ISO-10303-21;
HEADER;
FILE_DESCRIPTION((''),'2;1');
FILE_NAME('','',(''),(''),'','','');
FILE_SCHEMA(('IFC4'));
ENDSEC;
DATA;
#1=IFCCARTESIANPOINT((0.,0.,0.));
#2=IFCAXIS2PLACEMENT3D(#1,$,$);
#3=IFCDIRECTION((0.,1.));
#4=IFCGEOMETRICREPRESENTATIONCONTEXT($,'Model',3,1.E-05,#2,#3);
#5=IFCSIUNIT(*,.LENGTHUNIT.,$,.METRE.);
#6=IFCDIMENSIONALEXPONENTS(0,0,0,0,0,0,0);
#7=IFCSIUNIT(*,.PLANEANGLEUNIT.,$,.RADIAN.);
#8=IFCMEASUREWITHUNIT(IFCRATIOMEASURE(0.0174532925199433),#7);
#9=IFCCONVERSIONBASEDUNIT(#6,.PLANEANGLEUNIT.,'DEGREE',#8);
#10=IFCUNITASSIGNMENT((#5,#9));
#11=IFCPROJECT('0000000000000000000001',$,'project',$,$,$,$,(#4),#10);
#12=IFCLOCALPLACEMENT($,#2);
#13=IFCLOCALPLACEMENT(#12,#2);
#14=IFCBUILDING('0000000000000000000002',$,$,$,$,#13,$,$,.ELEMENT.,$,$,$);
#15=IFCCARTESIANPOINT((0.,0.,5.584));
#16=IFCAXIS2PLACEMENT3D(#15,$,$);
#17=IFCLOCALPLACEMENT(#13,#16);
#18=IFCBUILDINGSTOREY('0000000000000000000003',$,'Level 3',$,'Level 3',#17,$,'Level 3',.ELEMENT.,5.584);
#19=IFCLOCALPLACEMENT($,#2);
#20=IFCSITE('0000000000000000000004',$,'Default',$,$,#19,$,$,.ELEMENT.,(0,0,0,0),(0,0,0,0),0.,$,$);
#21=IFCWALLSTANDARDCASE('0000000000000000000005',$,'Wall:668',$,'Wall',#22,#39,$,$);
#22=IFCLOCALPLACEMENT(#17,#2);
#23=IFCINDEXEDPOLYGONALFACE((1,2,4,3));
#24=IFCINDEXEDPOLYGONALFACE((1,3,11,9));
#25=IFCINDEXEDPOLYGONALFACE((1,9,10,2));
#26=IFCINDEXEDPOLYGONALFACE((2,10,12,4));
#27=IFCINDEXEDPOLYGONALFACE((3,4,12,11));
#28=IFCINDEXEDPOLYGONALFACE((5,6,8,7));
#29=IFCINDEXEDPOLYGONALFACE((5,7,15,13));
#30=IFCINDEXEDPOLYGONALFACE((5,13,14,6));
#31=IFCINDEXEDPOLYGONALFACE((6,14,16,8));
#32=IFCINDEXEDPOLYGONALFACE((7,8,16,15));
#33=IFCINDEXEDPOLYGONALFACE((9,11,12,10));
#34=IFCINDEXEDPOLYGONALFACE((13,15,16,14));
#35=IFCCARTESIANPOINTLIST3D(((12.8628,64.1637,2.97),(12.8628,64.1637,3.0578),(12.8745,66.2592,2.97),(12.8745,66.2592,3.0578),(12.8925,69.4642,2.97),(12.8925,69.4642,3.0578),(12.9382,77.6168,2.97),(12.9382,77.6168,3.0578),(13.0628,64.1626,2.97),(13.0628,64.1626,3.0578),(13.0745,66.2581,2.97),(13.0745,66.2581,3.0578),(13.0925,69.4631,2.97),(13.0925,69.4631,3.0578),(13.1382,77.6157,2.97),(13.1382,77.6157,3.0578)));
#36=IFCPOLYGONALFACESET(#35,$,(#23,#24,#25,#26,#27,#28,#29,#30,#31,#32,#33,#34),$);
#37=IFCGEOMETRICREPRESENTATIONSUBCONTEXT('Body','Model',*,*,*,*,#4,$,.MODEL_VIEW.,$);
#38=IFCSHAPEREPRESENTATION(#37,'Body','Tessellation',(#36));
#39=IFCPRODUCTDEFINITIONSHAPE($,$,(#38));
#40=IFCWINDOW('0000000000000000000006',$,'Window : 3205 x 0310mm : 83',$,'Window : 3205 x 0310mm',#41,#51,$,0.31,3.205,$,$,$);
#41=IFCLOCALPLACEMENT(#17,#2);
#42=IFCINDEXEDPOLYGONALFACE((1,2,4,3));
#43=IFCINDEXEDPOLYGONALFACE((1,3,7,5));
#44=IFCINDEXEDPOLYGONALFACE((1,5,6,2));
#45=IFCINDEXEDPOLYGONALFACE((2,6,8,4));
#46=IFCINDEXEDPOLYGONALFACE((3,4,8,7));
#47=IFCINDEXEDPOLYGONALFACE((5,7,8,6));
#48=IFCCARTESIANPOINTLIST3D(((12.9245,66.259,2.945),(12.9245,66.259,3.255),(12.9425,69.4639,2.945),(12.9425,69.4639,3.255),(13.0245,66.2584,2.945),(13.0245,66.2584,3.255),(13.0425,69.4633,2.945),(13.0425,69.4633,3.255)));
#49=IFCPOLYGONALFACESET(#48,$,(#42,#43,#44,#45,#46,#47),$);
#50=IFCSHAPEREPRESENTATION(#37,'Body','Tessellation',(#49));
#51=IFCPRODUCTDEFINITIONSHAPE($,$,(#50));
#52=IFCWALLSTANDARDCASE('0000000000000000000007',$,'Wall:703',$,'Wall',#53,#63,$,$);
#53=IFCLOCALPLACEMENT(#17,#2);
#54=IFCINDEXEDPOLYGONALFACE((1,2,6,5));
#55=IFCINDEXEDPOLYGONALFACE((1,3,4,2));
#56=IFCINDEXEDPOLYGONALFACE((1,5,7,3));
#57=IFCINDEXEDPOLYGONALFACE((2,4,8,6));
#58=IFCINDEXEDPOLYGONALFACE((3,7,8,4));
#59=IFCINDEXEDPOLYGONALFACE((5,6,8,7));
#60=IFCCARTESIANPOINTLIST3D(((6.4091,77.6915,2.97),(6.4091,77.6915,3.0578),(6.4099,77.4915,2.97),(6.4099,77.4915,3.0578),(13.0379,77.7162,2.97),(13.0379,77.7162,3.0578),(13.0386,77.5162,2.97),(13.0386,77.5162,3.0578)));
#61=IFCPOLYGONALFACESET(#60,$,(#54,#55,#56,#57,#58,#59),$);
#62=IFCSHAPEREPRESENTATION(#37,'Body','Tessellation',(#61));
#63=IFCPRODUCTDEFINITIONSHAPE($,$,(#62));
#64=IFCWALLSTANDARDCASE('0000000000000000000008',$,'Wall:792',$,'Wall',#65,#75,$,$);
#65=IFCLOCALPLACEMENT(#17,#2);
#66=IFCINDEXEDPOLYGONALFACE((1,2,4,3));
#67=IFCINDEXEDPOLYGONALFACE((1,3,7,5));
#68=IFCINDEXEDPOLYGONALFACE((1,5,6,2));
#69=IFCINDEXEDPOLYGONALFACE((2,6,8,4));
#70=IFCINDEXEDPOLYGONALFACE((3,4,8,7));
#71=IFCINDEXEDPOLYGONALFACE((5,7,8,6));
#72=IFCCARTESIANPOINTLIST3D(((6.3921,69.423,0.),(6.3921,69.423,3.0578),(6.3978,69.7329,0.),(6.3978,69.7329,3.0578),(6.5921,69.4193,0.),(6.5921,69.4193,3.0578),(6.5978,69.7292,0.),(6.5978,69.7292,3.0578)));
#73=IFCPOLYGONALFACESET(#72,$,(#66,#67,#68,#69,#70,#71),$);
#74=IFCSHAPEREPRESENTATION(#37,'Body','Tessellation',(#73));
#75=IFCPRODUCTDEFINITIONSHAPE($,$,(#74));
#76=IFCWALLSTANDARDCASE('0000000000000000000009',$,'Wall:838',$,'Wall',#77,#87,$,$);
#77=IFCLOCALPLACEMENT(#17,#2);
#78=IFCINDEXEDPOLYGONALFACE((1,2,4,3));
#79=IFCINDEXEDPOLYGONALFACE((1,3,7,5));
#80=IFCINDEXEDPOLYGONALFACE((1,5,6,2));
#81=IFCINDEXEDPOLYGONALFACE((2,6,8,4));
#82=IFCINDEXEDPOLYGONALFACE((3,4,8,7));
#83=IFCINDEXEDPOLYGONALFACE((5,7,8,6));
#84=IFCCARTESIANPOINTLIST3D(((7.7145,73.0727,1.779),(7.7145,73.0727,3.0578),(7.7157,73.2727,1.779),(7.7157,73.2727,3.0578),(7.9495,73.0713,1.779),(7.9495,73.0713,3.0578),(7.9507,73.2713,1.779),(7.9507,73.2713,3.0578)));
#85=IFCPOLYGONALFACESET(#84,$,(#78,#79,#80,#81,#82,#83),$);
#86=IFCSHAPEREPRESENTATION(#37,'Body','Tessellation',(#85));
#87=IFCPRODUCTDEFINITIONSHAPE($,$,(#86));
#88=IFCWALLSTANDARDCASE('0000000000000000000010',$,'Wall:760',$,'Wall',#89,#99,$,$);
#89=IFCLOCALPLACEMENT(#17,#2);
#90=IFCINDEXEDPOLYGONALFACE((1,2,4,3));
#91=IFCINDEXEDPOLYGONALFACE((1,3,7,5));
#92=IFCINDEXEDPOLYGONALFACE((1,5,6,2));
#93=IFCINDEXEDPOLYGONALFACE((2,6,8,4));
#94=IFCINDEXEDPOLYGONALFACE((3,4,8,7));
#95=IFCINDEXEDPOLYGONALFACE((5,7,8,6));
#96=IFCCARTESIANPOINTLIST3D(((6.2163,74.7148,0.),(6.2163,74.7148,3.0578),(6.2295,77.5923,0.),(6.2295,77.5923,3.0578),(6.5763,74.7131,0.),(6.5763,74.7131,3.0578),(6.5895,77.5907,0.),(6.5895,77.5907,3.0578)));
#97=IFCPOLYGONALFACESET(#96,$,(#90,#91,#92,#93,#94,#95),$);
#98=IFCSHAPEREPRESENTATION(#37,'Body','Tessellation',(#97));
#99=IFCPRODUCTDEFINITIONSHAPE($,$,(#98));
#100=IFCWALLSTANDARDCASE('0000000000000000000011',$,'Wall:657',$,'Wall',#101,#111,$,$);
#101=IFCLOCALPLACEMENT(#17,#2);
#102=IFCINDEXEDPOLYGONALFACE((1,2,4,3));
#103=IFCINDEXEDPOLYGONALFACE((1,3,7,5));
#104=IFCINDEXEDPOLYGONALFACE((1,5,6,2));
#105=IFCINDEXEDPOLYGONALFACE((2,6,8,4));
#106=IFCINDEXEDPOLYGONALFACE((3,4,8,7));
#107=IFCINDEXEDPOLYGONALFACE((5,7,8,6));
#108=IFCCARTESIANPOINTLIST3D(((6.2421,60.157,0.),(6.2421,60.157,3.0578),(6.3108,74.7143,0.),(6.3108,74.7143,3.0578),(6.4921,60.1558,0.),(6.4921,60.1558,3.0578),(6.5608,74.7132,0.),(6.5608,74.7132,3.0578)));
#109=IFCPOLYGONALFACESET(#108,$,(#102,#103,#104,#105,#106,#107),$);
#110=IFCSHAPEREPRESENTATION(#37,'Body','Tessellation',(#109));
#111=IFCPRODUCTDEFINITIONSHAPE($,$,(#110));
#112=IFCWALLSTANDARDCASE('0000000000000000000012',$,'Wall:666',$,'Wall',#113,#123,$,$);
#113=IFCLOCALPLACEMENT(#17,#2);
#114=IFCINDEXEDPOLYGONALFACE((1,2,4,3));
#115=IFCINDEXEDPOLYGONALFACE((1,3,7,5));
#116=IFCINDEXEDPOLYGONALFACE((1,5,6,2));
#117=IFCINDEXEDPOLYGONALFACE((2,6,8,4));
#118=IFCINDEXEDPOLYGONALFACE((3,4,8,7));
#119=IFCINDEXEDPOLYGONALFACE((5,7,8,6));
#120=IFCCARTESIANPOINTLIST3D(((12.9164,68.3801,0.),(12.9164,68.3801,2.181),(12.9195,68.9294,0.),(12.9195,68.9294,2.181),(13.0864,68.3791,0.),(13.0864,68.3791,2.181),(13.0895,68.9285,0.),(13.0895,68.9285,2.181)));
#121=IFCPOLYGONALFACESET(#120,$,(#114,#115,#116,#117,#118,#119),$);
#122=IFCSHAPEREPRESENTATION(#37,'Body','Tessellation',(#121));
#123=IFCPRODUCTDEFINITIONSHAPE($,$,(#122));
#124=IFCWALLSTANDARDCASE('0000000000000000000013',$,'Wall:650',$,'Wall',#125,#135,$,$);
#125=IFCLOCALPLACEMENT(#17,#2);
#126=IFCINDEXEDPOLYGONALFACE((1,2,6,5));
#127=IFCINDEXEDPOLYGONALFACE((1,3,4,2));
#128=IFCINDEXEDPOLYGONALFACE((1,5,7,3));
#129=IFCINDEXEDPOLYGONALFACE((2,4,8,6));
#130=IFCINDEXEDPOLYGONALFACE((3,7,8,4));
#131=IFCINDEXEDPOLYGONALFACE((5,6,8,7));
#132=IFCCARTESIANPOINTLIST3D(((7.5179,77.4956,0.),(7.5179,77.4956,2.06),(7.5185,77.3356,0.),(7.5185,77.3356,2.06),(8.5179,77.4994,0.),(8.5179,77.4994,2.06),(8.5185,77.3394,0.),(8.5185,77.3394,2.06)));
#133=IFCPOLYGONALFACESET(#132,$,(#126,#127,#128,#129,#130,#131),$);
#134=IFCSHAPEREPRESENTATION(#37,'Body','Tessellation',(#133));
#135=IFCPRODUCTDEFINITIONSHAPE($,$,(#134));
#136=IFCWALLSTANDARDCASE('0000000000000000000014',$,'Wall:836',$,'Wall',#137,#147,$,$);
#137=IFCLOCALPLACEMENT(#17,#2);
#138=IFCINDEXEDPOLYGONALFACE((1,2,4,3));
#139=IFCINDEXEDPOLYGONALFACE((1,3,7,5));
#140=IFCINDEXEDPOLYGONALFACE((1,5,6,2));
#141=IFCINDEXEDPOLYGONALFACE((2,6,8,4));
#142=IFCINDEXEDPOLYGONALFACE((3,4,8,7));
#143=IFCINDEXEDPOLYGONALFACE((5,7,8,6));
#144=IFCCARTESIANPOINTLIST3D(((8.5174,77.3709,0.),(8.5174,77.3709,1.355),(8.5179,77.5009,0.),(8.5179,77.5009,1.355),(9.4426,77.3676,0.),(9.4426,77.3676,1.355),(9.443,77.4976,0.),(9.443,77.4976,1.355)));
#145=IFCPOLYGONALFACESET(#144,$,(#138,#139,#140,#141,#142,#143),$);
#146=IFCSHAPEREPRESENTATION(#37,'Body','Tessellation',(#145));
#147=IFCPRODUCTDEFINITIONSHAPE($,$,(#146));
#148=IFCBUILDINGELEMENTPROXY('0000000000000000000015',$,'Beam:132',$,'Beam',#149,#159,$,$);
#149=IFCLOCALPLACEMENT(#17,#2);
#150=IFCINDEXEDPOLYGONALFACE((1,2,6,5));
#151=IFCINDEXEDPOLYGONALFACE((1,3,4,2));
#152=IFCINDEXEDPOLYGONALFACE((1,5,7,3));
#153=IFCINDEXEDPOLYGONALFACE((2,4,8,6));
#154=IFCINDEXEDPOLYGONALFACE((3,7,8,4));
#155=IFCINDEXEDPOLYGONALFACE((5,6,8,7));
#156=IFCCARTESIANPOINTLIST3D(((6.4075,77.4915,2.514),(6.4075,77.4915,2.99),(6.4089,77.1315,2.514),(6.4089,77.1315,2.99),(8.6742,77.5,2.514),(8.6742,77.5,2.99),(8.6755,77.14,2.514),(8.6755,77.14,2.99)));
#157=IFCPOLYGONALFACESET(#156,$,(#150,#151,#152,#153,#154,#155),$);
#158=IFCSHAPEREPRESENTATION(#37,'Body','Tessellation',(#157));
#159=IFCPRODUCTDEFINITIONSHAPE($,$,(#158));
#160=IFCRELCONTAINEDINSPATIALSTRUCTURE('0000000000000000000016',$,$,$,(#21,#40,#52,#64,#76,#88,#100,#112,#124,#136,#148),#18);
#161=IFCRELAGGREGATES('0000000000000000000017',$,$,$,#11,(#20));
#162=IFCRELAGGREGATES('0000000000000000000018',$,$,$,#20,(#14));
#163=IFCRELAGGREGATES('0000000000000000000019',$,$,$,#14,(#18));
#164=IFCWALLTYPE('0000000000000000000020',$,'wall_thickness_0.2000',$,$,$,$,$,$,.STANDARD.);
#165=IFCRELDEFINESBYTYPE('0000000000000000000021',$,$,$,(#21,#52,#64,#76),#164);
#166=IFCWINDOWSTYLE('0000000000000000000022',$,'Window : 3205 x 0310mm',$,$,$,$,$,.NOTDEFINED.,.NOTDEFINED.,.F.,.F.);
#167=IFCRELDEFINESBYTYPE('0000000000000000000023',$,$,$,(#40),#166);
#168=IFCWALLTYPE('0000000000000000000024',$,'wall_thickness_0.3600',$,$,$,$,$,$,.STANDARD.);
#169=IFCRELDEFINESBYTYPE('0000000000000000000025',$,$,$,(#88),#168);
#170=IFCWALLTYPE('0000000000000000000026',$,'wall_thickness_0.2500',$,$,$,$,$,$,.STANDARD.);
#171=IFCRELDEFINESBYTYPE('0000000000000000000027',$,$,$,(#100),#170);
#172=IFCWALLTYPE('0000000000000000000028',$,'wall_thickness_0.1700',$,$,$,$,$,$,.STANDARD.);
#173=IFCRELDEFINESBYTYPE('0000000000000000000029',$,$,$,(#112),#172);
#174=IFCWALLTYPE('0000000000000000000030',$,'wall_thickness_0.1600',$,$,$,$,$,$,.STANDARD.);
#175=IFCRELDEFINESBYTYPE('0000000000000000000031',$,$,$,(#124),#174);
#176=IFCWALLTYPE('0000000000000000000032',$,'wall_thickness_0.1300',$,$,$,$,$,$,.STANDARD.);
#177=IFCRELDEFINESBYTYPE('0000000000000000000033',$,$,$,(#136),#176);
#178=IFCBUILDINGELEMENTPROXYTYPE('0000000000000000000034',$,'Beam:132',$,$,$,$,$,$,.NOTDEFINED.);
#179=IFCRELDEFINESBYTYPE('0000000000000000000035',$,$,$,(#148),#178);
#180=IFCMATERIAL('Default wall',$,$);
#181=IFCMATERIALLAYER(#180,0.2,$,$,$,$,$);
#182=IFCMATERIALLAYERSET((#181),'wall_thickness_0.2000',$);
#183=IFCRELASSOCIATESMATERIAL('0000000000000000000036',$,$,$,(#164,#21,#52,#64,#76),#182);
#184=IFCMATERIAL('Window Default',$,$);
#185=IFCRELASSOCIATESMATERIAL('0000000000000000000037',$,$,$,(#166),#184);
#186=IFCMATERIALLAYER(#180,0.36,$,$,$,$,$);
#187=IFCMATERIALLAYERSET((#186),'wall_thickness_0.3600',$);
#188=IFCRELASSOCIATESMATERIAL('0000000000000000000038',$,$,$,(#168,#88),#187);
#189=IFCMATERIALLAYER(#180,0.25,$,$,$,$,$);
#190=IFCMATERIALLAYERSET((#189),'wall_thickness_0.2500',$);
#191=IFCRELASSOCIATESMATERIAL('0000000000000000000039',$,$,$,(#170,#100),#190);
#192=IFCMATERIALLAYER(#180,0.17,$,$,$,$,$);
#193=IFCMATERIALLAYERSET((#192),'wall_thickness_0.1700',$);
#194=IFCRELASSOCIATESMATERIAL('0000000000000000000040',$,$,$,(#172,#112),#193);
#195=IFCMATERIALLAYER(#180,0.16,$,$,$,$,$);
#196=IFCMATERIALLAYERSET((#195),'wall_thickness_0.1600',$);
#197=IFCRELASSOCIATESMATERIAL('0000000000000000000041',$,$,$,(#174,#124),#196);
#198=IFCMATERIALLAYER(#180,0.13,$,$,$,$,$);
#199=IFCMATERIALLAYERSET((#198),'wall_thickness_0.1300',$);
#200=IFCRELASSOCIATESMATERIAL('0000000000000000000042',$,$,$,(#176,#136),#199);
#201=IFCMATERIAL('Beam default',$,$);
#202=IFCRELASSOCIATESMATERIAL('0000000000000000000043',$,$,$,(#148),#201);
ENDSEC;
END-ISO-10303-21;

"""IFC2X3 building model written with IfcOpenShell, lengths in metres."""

from ifc_helpers import new_model, entity, si_unit, converted_unit, direction, frame, frame_2d, origin, origin_2d_with_axis, place, context, subcontext, project, spatial, polyline, rectangle, outline, extrude, source, transform, mapped, material, layer, layer_set, layer_usage, type_object, type_shapes, element, fill, save


model = new_model("IFC2X3")

# Units and contexts
model_context = context("Model", 3, precision=1e-05, world=origin(), true_north=direction((0.0, 1.0)))
body_context = subcontext(model_context, "Body", "Model", "MODEL_VIEW")
ifc_project = project(units=[si_unit("LENGTHUNIT", "METRE"), converted_unit("PLANEANGLEUNIT", "DEGREE", entity("IfcRatioMeasure", 0.0174532925199433), si_unit("PLANEANGLEUNIT", "RADIAN"), dimensions=[0, 0, 0, 0, 0, 0, 0])], contexts=[model_context])

# Site, building, storey
site_placement = place(None, origin())
site = spatial("IfcSite", under=ifc_project, at=site_placement, Name="Default", CompositionType="ELEMENT", RefLatitude=(0, 0, 0, 0), RefLongitude=(0, 0, 0, 0), RefElevation=0.0)
placement_1 = place(None, origin())
building_placement = place(placement_1, origin())
building = spatial("IfcBuilding", under=site, at=building_placement, CompositionType="ELEMENT")
storey_placement = place(building_placement, frame((0.0, 0.0, 5.584)))
storey = spatial("IfcBuildingStorey", under=building, at=storey_placement, Name="Level 3", ObjectType="Level 3", LongName="Level 3", CompositionType="ELEMENT", Elevation=5.584)

# Shared definitions
ifc_material_1 = material(Name="Default wall")
ifc_material_2 = material(Name="Window Default")

# Wall, opening, window
ifc_layer_1 = layer(ifc_material_1, 0.2)
ifc_layer_set_1 = layer_set([ifc_layer_1], Name="wall_thickness_0.2000")
ifc_layer_usage_1 = layer_usage(ifc_layer_set_1, "AXIS2", "POSITIVE", -0.1)
wall_type_1 = type_object("IfcWallType", Name="wall_thickness_0.2000", PredefinedType="STANDARD", material=ifc_layer_set_1)
placement_2 = place(building_placement, frame((0.0, 0.0, 8.554)))
wall_1_placement = place(placement_2, frame((13.0382, 77.6162, 0.0), z_axis=(0.0, 0.0, 1.0), x_axis=(-0.005611, -0.999984, 0.0)))
wall_1 = element("IfcWallStandardCase", 1, at=wall_1_placement, inside=storey, type_object=wall_type_1, material=ifc_layer_usage_1, Name="Wall:668", ObjectType="Wall", context=body_context, shape_type="SweptSolid", body=[
    extrude(outline(polyline([(13.4533, -0.1), (13.4533, 0.1), (0.0, 0.1), (0.0, -0.1), (13.4533, -0.1)])), origin(), (0.0, 0.0, 1.0), 0.0878),
])
opening_1_placement = place(wall_1_placement, frame((8.1527, -0.1, -0.025)))
opening_1 = element("IfcOpeningElement", 2, at=opening_1_placement, cuts=wall_1, ObjectType="Opening", context=body_context, shape_type="SweptSolid", body=[
    extrude(rectangle(XDim=3.205, YDim=0.31, at=frame_2d((0.155, 1.6025), x_axis=(0.0, 1.0))), frame((0.0, 0.0, 0.0), z_axis=(0.0, 1.0, 0.0), x_axis=(0.0, 0.0, 1.0)), (0.0, 0.0, 1.0), 0.2),
])
window_style_1 = type_object("IfcWindowStyle", Name="Window : 3205 x 0310mm", ConstructionType="NOTDEFINED", OperationType="NOTDEFINED", ParameterTakesPrecedence=False, Sizeable=False, material=ifc_material_2)
shared_shape_1 = source(origin(), body_context, "Body", "SweptSolid", [
    extrude(rectangle(XDim=0.1, YDim=3.205, at=origin_2d_with_axis()), frame((1.6025, 0.1, 0.0), z_axis=(0.0, 0.0, 1.0), x_axis=(0.0, 1.0, 0.0)), (0.0, 0.0, 1.0), 0.31),
])
type_shapes(window_style_1, [shared_shape_1])
window_1_placement = place(opening_1_placement, origin())
window_1 = element("IfcWindow", 3, at=window_1_placement, inside=storey, type_object=window_style_1, Name="Window : 3205 x 0310mm : 83", ObjectType="Window : 3205 x 0310mm", OverallHeight=0.31, OverallWidth=3.205, context=body_context, shape_type="MappedRepresentation", body=[
    mapped(shared_shape_1, transform((0.0, 0.0, 0.0), scale=1.0)),
])
fill(opening_1, window_1)

# Walls
placement_3 = place(building_placement, frame((0.0, 0.0, 8.554)))
wall_2_placement = place(placement_3, frame((6.4095, 77.5915, 0.0), z_axis=(0.0, 0.0, 1.0), x_axis=(0.999993, 0.00373, 0.0)))
element("IfcWallStandardCase", 4, at=wall_2_placement, inside=storey, type_object=wall_type_1, material=ifc_layer_usage_1, Name="Wall:703", ObjectType="Wall", context=body_context, shape_type="SweptSolid", body=[
    extrude(outline(polyline([(6.6288, -0.1), (6.6288, 0.1), (0.0, 0.1), (0.0, -0.1), (6.6288, -0.1)])), origin(), (0.0, 0.0, 1.0), 0.0878),
])
wall_3_placement = place(storey_placement, frame((6.4978, 69.7311, 0.0), z_axis=(0.0, 0.0, 1.0), x_axis=(-0.018449, -0.99983, 0.0)))
element("IfcWallStandardCase", 5, at=wall_3_placement, inside=storey, type_object=wall_type_1, material=ifc_layer_usage_1, Name="Wall:792", ObjectType="Wall", context=body_context, shape_type="SweptSolid", body=[
    extrude(outline(polyline([(0.31, -0.1), (0.31, 0.1), (0.0, 0.1), (0.0, -0.1), (0.31, -0.1)])), origin(), (0.0, 0.0, 1.0), 3.0578),
])
placement_4 = place(building_placement, frame((0.0, 0.0, 7.363)))
wall_4_placement = place(placement_4, frame((7.9501, 73.1713, 0.0), z_axis=(0.0, 0.0, 1.0), x_axis=(-0.99998, 0.006266, 0.0)))
element("IfcWallStandardCase", 6, at=wall_4_placement, inside=storey, type_object=wall_type_1, material=ifc_layer_usage_1, Name="Wall:838", ObjectType="Wall", context=body_context, shape_type="SweptSolid", body=[
    extrude(outline(polyline([(0.235, -0.1), (0.235, 0.1), (0.0, 0.1), (0.0, -0.1), (0.235, -0.1)])), origin(), (0.0, 0.0, 1.0), 1.2788),
])
ifc_layer_2 = layer(ifc_material_1, 0.36)
ifc_layer_set_2 = layer_set([ifc_layer_2], Name="wall_thickness_0.3600")
ifc_layer_usage_2 = layer_usage(ifc_layer_set_2, "AXIS2", "POSITIVE", -0.18)
wall_type_2 = type_object("IfcWallType", Name="wall_thickness_0.3600", PredefinedType="STANDARD", material=ifc_layer_set_2)
wall_5_placement = place(storey_placement, frame((6.4095, 77.5915, 0.0), z_axis=(0.0, 0.0, 1.0), x_axis=(-0.004577, -0.99999, 0.0)))
element("IfcWallStandardCase", 7, at=wall_5_placement, inside=storey, type_object=wall_type_2, material=ifc_layer_usage_2, Name="Wall:760", ObjectType="Wall", context=body_context, shape_type="SweptSolid", body=[
    extrude(outline(polyline([(2.8776, -0.18), (2.8776, 0.18), (0.0, 0.18), (0.0, -0.18), (2.8776, -0.18)])), origin(), (0.0, 0.0, 1.0), 3.0578),
])
ifc_layer_3 = layer(ifc_material_1, 0.25)
ifc_layer_set_3 = layer_set([ifc_layer_3], Name="wall_thickness_0.2500")
ifc_layer_usage_3 = layer_usage(ifc_layer_set_3, "AXIS2", "POSITIVE", -0.125)
wall_type_3 = type_object("IfcWallType", Name="wall_thickness_0.2500", PredefinedType="STANDARD", material=ifc_layer_set_3)
wall_6_placement = place(storey_placement, frame((6.4358, 74.7137, 0.0), z_axis=(0.0, 0.0, 1.0), x_axis=(-0.004722, -0.999989, 0.0)))
element("IfcWallStandardCase", 8, at=wall_6_placement, inside=storey, type_object=wall_type_3, material=ifc_layer_usage_3, Name="Wall:657", ObjectType="Wall", context=body_context, shape_type="SweptSolid", body=[
    extrude(outline(polyline([(14.5575, -0.125), (14.5575, 0.125), (0.0, 0.125), (0.0, -0.125), (14.5575, -0.125)])), origin(), (0.0, 0.0, 1.0), 3.0578),
])
ifc_layer_4 = layer(ifc_material_1, 0.17)
ifc_layer_set_4 = layer_set([ifc_layer_4], Name="wall_thickness_0.1700")
ifc_layer_usage_4 = layer_usage(ifc_layer_set_4, "AXIS2", "POSITIVE", -0.085)
wall_type_4 = type_object("IfcWallType", Name="wall_thickness_0.1700", PredefinedType="STANDARD", material=ifc_layer_set_4)
wall_7_placement = place(storey_placement, frame((13.0045, 68.929, 0.0), z_axis=(0.0, 0.0, 1.0), x_axis=(-0.005612, -0.999984, 0.0)))
element("IfcWallStandardCase", 9, at=wall_7_placement, inside=storey, type_object=wall_type_4, material=ifc_layer_usage_4, Name="Wall:666", ObjectType="Wall", context=body_context, shape_type="SweptSolid", body=[
    extrude(outline(polyline([(0.5494, -0.085), (0.5494, 0.085), (0.0, 0.085), (0.0, -0.085), (0.5494, -0.085)])), origin(), (0.0, 0.0, 1.0), 2.181),
])
ifc_layer_5 = layer(ifc_material_1, 0.16)
ifc_layer_set_5 = layer_set([ifc_layer_5], Name="wall_thickness_0.1600")
ifc_layer_usage_5 = layer_usage(ifc_layer_set_5, "AXIS2", "POSITIVE", -0.08)
wall_type_5 = type_object("IfcWallType", Name="wall_thickness_0.1600", PredefinedType="STANDARD", material=ifc_layer_set_5)
wall_8_placement = place(storey_placement, frame((7.5182, 77.4156, 0.0), z_axis=(0.0, 0.0, 1.0), x_axis=(0.999993, 0.003738, 0.0)))
element("IfcWallStandardCase", 10, at=wall_8_placement, inside=storey, type_object=wall_type_5, material=ifc_layer_usage_5, Name="Wall:650", ObjectType="Wall", context=body_context, shape_type="SweptSolid", body=[
    extrude(outline(polyline([(1.0, -0.08), (1.0, 0.08), (0.0, 0.08), (0.0, -0.08), (1.0, -0.08)])), origin(), (0.0, 0.0, 1.0), 2.06),
])
ifc_layer_6 = layer(ifc_material_1, 0.13)
ifc_layer_set_6 = layer_set([ifc_layer_6], Name="wall_thickness_0.1300")
ifc_layer_usage_6 = layer_usage(ifc_layer_set_6, "AXIS2", "POSITIVE", -0.065)
wall_type_6 = type_object("IfcWallType", Name="wall_thickness_0.1300", PredefinedType="STANDARD", material=ifc_layer_set_6)
wall_9_placement = place(storey_placement, frame((8.5177, 77.4359, 0.0), z_axis=(0.0, 0.0, 1.0), x_axis=(0.999994, -0.003538, 0.0)))
element("IfcWallStandardCase", 11, at=wall_9_placement, inside=storey, type_object=wall_type_6, material=ifc_layer_usage_6, Name="Wall:836", ObjectType="Wall", context=body_context, shape_type="SweptSolid", body=[
    extrude(outline(polyline([(0.9251, -0.065), (0.9251, 0.065), (0.0, 0.065), (0.0, -0.065), (0.9251, -0.065)])), origin(), (0.0, 0.0, 1.0), 1.355),
])

# Building element proxy
ifc_material_3 = material(Name="Beam default")
building_element_proxy_type = type_object("IfcBuildingElementProxyType", Name="Beam:132", PredefinedType="NOTDEFINED")
shared_shape_2 = source(origin(), body_context, "Body", "SweptSolid", [
    extrude(outline(polyline([(2.2666, -0.18), (2.2666, 0.18), (0.0, 0.18), (0.0, -0.18), (2.2666, -0.18)])), origin(), (0.0, 0.0, 1.0), 0.476),
])
type_shapes(building_element_proxy_type, [shared_shape_2])
placement_5 = place(building_placement, frame((0.0, 0.0, 8.098)))
proxy_placement = place(placement_5, frame((6.4082, 77.3115, 0.0), z_axis=(0.0, 0.0, 1.0), x_axis=(0.999993, 0.003736, 0.0)))
element("IfcBuildingElementProxy", 12, at=proxy_placement, inside=storey, type_object=building_element_proxy_type, material=ifc_material_3, Name="Beam:132", ObjectType="Beam", context=body_context, shape_type="MappedRepresentation", body=[
    mapped(shared_shape_2, transform((0.0, 0.0, 0.0), scale=1.0)),
])

save(model, "model.ifc")
